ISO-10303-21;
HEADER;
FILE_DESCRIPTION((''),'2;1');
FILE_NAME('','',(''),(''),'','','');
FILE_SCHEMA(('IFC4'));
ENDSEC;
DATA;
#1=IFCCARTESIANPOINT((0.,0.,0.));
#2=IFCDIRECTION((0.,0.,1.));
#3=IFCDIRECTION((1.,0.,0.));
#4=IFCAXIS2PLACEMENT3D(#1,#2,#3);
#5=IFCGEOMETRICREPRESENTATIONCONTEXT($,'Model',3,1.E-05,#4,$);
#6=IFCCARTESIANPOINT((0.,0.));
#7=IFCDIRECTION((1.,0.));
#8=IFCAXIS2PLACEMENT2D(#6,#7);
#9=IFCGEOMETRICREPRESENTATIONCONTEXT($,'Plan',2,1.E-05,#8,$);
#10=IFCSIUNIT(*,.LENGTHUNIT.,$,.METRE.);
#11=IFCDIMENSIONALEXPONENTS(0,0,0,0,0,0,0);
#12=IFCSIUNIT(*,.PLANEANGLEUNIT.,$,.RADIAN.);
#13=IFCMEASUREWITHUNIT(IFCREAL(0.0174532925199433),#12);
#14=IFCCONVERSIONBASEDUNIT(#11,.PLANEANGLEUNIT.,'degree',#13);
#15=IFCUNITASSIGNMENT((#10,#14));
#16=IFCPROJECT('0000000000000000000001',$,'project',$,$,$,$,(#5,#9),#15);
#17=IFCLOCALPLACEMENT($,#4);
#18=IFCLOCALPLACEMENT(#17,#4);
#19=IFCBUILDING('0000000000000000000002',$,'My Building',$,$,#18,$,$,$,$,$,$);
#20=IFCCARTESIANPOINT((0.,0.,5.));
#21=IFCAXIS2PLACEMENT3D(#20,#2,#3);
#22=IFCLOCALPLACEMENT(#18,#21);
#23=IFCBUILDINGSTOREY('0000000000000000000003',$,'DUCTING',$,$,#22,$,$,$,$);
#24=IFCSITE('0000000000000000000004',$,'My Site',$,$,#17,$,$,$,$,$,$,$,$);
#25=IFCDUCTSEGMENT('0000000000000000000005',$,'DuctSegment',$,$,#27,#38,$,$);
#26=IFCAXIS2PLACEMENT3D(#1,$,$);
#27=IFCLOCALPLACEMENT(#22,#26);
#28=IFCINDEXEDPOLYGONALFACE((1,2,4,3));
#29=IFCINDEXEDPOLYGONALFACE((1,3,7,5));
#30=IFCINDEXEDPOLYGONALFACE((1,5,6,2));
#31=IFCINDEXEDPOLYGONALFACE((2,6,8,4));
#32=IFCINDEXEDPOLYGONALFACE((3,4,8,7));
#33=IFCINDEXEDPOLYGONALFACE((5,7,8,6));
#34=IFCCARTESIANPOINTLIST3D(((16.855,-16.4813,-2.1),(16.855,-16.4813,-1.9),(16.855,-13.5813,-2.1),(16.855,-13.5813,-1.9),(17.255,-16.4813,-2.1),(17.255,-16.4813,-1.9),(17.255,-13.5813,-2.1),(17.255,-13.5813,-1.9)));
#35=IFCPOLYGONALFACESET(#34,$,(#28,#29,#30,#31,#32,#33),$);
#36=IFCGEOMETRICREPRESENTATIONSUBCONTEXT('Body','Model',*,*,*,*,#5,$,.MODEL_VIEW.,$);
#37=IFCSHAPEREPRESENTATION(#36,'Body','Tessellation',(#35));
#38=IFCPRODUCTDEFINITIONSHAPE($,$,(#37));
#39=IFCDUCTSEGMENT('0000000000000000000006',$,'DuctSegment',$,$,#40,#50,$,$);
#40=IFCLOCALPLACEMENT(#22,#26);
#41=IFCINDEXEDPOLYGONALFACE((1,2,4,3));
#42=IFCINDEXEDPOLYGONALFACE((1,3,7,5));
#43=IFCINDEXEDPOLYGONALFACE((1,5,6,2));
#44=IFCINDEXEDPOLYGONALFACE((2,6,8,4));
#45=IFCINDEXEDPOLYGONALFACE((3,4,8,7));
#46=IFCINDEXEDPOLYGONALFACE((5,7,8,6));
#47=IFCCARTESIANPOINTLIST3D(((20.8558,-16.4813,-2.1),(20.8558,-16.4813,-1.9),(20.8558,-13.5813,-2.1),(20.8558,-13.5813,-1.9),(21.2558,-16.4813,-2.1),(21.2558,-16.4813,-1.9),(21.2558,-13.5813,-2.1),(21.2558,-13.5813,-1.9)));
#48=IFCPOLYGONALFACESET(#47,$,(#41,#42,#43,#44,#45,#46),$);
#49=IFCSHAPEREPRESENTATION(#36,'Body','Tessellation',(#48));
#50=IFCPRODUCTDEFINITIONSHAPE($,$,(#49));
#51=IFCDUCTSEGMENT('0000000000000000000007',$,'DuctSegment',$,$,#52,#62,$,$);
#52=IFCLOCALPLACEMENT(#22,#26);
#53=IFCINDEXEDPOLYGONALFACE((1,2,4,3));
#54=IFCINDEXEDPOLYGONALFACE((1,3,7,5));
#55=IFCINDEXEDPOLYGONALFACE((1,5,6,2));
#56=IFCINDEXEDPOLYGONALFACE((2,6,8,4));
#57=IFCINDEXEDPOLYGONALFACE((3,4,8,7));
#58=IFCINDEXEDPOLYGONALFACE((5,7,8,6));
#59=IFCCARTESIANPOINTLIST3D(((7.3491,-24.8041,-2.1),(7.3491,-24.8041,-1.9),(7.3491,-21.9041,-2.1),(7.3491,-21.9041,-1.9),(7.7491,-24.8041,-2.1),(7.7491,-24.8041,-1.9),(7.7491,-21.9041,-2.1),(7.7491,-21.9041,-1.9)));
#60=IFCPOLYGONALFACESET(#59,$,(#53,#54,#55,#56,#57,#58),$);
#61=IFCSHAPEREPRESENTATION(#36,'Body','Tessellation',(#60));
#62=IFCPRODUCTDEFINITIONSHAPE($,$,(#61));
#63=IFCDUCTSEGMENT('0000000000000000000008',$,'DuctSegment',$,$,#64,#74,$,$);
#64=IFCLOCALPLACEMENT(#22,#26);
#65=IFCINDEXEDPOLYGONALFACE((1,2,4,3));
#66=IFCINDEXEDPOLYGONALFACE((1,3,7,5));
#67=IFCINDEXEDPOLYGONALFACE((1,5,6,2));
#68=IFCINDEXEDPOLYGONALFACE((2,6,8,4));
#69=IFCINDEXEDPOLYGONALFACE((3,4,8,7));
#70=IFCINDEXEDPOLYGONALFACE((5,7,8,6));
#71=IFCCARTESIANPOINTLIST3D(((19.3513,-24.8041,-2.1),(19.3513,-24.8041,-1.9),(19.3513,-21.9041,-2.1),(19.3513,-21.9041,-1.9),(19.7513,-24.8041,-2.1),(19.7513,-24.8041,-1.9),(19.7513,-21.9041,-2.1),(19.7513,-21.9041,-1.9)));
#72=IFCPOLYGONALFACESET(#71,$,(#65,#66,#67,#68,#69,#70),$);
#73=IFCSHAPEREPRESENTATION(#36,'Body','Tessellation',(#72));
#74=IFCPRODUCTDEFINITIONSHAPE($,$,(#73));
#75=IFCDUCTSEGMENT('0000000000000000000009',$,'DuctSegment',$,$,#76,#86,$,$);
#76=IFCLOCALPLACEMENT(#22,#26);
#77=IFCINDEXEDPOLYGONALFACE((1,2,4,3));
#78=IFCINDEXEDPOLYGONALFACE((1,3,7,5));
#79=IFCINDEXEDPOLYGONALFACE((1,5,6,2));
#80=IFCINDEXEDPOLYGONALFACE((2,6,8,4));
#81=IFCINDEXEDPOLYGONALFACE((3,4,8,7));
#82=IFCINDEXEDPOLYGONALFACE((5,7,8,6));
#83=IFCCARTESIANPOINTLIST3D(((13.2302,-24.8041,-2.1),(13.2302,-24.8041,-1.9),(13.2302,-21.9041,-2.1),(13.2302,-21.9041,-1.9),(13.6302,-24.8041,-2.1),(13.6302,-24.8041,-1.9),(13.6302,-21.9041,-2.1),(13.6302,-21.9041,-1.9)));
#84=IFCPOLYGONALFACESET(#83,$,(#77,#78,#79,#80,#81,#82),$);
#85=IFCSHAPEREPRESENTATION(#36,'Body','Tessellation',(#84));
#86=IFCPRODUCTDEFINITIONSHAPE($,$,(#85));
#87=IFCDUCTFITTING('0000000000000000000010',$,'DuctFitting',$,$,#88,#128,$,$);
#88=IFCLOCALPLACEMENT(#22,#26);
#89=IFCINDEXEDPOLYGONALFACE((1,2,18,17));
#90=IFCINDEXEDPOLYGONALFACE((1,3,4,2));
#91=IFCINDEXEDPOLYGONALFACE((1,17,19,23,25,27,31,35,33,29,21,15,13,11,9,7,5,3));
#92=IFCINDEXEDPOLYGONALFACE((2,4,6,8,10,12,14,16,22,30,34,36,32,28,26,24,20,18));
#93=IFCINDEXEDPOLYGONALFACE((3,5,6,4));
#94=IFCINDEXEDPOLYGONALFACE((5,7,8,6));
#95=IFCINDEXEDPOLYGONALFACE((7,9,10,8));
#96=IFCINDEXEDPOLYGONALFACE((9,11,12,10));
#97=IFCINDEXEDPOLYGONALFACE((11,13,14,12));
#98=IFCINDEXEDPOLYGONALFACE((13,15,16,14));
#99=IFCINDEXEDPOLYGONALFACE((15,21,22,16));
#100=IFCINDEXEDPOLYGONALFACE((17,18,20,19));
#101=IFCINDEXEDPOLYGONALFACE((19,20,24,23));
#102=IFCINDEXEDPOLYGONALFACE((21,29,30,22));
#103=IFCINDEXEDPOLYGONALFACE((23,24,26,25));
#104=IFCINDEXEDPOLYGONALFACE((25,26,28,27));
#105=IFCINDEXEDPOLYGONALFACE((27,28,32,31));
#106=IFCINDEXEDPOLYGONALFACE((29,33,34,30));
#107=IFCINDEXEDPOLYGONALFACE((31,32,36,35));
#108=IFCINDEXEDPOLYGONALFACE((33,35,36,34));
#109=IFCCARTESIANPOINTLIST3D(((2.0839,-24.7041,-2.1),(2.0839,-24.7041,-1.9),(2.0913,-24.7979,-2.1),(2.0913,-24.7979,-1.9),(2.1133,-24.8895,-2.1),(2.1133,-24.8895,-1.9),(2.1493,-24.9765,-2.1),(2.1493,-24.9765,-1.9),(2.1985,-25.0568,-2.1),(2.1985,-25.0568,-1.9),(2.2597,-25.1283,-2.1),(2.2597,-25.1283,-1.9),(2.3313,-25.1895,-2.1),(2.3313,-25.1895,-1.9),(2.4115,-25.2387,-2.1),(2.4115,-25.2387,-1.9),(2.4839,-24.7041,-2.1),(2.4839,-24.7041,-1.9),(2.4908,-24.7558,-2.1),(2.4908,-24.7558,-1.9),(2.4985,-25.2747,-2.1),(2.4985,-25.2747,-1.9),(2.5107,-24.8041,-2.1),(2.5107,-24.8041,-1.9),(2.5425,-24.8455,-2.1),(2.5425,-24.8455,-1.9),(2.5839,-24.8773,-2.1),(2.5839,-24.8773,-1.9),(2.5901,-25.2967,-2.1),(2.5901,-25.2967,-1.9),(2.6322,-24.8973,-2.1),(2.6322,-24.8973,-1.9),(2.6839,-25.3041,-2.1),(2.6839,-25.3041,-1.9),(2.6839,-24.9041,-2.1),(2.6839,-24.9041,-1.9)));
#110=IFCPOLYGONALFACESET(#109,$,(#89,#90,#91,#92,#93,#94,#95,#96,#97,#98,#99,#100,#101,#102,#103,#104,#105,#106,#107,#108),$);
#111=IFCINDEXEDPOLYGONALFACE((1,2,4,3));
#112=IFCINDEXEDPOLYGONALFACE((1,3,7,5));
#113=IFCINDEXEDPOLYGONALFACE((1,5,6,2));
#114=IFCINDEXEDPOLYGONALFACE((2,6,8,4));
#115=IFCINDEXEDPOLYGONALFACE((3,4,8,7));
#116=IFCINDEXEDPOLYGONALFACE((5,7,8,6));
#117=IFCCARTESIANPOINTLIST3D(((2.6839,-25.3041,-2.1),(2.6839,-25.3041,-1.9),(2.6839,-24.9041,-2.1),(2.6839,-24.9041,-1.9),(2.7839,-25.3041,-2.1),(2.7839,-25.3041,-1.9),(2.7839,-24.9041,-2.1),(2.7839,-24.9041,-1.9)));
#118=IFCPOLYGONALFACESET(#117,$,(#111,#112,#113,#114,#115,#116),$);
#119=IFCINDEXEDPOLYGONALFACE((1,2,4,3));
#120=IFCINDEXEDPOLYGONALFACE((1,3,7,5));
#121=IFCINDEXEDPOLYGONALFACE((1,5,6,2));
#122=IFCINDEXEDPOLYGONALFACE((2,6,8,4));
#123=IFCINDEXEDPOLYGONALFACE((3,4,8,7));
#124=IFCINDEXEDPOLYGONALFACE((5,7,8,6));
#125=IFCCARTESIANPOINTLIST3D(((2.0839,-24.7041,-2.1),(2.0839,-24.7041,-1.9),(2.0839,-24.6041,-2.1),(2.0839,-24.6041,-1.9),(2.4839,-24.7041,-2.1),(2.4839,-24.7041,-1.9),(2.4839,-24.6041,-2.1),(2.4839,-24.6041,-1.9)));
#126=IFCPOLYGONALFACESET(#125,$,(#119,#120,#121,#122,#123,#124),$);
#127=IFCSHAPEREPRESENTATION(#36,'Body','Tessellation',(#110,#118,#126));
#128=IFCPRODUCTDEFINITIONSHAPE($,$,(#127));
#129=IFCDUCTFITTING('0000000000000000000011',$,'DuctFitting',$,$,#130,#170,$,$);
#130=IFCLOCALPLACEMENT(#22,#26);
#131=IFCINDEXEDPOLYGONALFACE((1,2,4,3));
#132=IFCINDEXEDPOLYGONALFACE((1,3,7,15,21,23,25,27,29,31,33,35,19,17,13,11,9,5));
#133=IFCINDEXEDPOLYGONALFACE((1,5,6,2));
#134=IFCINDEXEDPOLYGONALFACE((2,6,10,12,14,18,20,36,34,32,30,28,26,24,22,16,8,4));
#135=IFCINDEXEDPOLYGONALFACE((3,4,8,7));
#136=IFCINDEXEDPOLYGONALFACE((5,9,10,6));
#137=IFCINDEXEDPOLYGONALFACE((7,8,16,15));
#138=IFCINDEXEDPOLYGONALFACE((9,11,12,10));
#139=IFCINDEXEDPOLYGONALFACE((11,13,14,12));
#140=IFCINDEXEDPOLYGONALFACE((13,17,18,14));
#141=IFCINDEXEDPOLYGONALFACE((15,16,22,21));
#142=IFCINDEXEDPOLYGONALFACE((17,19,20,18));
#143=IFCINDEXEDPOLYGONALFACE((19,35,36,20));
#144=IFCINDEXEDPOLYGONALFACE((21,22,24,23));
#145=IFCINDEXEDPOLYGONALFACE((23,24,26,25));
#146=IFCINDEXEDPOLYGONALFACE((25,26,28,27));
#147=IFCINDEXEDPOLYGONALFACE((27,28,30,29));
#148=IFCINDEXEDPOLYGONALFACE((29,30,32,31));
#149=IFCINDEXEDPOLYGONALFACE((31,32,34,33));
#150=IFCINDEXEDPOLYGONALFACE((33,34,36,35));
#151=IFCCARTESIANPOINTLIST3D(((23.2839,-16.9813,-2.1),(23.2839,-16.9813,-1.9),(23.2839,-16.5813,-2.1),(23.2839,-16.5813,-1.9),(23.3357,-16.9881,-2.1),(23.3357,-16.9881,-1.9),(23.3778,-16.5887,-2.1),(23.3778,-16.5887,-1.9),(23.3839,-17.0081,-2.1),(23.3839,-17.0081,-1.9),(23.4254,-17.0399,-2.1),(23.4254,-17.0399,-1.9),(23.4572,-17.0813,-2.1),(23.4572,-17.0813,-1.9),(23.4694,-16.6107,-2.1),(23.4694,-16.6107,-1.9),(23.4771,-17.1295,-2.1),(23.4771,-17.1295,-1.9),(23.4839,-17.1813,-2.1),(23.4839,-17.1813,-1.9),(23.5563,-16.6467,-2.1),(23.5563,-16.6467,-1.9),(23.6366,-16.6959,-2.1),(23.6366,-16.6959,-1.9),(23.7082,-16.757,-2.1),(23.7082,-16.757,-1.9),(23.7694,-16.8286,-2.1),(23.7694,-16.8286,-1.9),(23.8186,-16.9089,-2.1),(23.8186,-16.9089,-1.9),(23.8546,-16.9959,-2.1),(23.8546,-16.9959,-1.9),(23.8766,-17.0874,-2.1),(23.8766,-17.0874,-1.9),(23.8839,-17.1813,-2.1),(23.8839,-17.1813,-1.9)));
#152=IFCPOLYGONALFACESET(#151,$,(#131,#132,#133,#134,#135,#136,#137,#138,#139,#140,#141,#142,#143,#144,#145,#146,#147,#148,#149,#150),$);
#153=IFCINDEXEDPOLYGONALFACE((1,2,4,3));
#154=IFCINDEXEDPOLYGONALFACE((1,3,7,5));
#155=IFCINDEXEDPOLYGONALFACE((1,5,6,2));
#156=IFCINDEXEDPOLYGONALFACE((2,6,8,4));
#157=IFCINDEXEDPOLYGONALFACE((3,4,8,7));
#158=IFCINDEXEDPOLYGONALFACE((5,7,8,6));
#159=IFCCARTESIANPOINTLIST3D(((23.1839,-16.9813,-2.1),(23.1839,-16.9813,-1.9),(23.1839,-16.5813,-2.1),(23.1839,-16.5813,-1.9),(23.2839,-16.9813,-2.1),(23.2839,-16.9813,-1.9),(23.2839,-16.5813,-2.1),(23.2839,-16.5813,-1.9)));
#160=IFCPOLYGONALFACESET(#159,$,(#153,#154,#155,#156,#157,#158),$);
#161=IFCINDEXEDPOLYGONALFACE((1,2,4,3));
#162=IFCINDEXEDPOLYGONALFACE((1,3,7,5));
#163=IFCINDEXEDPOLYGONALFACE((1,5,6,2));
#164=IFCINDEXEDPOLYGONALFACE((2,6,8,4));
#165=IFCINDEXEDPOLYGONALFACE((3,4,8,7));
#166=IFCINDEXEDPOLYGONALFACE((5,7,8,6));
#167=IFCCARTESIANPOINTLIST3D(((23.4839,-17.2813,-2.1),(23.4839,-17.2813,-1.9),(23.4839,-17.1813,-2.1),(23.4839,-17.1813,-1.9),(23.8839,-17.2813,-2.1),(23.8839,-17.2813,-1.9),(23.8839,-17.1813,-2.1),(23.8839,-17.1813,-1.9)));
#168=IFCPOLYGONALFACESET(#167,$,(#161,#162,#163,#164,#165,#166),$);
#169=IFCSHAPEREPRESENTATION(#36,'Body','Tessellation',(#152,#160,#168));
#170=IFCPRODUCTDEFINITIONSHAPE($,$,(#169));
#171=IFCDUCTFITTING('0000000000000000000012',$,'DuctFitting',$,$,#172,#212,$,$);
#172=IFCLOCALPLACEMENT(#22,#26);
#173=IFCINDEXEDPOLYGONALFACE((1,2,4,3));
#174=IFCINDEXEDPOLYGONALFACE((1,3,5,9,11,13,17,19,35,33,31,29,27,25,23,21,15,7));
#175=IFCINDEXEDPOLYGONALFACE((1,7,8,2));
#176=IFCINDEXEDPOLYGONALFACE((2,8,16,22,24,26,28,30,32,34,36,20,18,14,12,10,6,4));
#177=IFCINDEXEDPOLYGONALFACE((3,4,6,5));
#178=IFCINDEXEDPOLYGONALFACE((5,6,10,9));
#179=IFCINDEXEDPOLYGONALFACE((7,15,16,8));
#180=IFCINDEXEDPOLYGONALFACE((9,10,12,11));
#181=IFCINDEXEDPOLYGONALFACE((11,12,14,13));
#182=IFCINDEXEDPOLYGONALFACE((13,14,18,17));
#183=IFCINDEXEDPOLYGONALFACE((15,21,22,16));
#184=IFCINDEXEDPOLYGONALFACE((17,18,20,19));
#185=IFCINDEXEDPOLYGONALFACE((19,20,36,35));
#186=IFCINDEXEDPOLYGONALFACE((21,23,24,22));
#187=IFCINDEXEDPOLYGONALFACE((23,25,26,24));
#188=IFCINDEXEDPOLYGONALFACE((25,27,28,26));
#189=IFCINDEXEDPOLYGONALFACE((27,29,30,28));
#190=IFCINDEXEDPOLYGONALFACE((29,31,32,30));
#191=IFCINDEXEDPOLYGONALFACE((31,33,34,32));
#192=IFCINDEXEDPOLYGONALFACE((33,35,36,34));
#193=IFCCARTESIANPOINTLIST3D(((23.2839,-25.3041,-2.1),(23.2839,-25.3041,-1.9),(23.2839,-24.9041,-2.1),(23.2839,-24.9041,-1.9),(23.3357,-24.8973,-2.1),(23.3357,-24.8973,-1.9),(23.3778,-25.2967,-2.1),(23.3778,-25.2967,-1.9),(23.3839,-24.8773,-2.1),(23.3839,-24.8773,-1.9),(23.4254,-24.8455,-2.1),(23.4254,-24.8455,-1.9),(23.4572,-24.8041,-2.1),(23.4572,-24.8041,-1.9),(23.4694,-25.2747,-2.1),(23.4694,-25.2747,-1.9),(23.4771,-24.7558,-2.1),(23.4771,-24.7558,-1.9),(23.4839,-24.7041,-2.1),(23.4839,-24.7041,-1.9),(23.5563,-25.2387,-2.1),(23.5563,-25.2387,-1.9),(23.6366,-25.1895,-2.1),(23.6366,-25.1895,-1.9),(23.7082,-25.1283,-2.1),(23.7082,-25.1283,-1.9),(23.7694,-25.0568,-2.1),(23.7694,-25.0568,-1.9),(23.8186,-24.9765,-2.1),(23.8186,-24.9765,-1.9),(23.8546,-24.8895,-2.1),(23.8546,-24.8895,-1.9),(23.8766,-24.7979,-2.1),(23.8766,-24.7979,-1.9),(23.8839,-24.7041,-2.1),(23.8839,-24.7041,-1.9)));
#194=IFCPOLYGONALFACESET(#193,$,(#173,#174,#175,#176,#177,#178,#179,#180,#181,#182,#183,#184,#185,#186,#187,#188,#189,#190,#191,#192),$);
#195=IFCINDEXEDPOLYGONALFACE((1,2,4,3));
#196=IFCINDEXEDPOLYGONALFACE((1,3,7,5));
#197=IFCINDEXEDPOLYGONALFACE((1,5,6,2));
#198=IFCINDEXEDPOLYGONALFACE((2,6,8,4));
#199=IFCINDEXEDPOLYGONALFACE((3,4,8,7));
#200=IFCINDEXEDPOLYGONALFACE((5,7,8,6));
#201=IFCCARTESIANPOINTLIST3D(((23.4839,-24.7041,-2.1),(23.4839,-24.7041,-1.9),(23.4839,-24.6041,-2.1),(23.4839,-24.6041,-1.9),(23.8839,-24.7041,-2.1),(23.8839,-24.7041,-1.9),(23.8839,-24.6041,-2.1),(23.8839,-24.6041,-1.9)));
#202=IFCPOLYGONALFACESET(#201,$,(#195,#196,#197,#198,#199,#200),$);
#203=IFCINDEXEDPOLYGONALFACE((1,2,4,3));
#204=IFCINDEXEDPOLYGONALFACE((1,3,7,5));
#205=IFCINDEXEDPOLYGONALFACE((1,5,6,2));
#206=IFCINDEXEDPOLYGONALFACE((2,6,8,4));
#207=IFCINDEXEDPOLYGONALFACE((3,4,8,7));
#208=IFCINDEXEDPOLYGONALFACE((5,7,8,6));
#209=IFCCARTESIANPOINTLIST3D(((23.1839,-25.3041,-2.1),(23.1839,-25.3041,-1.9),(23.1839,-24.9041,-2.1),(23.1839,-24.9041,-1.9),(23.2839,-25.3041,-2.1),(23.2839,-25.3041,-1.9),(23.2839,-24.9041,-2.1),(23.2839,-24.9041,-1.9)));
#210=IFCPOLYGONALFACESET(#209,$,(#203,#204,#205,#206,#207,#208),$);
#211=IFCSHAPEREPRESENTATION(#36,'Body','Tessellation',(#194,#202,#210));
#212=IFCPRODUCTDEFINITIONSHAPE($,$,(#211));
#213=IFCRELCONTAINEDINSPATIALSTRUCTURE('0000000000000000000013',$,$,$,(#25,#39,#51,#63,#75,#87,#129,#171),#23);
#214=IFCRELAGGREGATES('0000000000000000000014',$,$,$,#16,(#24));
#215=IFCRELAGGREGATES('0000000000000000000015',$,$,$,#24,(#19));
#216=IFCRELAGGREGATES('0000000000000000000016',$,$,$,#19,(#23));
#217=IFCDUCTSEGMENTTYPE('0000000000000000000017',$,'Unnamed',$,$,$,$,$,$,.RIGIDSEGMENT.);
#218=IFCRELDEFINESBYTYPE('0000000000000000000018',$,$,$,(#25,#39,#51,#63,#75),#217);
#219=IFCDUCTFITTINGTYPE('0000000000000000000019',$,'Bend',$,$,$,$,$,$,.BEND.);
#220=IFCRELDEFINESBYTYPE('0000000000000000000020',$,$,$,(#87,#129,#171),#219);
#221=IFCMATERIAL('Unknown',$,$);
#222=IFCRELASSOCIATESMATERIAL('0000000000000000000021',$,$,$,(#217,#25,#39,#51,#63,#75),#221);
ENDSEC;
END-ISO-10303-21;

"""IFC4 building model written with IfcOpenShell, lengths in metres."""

from ifc_helpers import new_model, entity, si_unit, converted_unit, frame, origin_with_axes, origin_2d_with_axis, place, context, subcontext, project, spatial, line, arc, indexed_curve, rectangle, outline, extrude, source, transform, mapped, material, material_profile, profile_set, profile_usage, type_object, type_shapes, element, save


model = new_model("IFC4")

# Units and contexts
model_context = context("Model", 3, precision=1e-05, world=origin_with_axes())
plan_context = context("Plan", 2, precision=1e-05, world=origin_2d_with_axis())
body_context = subcontext(model_context, "Body", "Model", "MODEL_VIEW")
ifc_project = project(units=[si_unit("LENGTHUNIT", "METRE"), converted_unit("PLANEANGLEUNIT", "degree", entity("IfcReal", 0.0174532925199433), si_unit("PLANEANGLEUNIT", "RADIAN"), dimensions=[0, 0, 0, 0, 0, 0, 0])], contexts=[model_context, plan_context])

# Site, building, storey
site_placement = place(None, origin_with_axes())
site = spatial("IfcSite", under=ifc_project, at=site_placement, Name="My Site")
building_placement = place(site_placement, origin_with_axes())
building = spatial("IfcBuilding", under=site, at=building_placement, Name="My Building")
storey_placement = place(building_placement, frame((0.0, 0.0, 5.0), z_axis=(0.0, 0.0, 1.0), x_axis=(1.0, 0.0, 0.0)))
storey = spatial("IfcBuildingStorey", under=building, at=storey_placement, Name="DUCTING")

# Duct segments
ifc_material = material(Name="Unknown")
ifc_material_profile = material_profile(ifc_material, rectangle(XDim=0.4, YDim=0.2))
ifc_profile_set = profile_set([ifc_material_profile])
duct_segment_type = type_object("IfcDuctSegmentType", Name="Unnamed", PredefinedType="RIGIDSEGMENT", material=ifc_profile_set)
ifc_profile_usage_1 = profile_usage(ifc_profile_set, cardinal=5)
duct_segment_1_placement = place(storey_placement, frame((17.055, -13.5813, -2.0), z_axis=(0.0, -1.0, 0.0), x_axis=(1.0, 0.0, 0.0)))
element("IfcDuctSegment", 1, at=duct_segment_1_placement, inside=storey, type_object=duct_segment_type, material=ifc_profile_usage_1, Name="DuctSegment", context=body_context, shape_type="SweptSolid", body=[
    extrude(rectangle(XDim=0.4, YDim=0.2), origin_with_axes(), (0.0, 0.0, 1.0), 2.9),
])
ifc_profile_usage_2 = profile_usage(ifc_profile_set, cardinal=5)
duct_segment_2_placement = place(storey_placement, frame((21.0558, -13.5813, -2.0), z_axis=(0.0, -1.0, 0.0), x_axis=(1.0, 0.0, 0.0)))
element("IfcDuctSegment", 2, at=duct_segment_2_placement, inside=storey, type_object=duct_segment_type, material=ifc_profile_usage_2, Name="DuctSegment", context=body_context, shape_type="SweptSolid", body=[
    extrude(rectangle(XDim=0.4, YDim=0.2), origin_with_axes(), (0.0, 0.0, 1.0), 2.9),
])
ifc_profile_usage_3 = profile_usage(ifc_profile_set, cardinal=5)
duct_segment_3_placement = place(storey_placement, frame((7.5491, -21.9041, -2.0), z_axis=(0.0, -1.0, 0.0), x_axis=(1.0, 0.0, 0.0)))
element("IfcDuctSegment", 3, at=duct_segment_3_placement, inside=storey, type_object=duct_segment_type, material=ifc_profile_usage_3, Name="DuctSegment", context=body_context, shape_type="SweptSolid", body=[
    extrude(rectangle(XDim=0.4, YDim=0.2), origin_with_axes(), (0.0, 0.0, 1.0), 2.9),
])
ifc_profile_usage_4 = profile_usage(ifc_profile_set, cardinal=5)
duct_segment_4_placement = place(storey_placement, frame((19.5513, -21.9041, -2.0), z_axis=(0.0, -1.0, 0.0), x_axis=(1.0, 0.0, 0.0)))
element("IfcDuctSegment", 4, at=duct_segment_4_placement, inside=storey, type_object=duct_segment_type, material=ifc_profile_usage_4, Name="DuctSegment", context=body_context, shape_type="SweptSolid", body=[
    extrude(rectangle(XDim=0.4, YDim=0.2), origin_with_axes(), (0.0, 0.0, 1.0), 2.9),
])
ifc_profile_usage_5 = profile_usage(ifc_profile_set, cardinal=5)
duct_segment_5_placement = place(storey_placement, frame((13.4302, -21.9041, -2.0), z_axis=(0.0, -1.0, 0.0), x_axis=(1.0, 0.0, 0.0)))
element("IfcDuctSegment", 5, at=duct_segment_5_placement, inside=storey, type_object=duct_segment_type, material=ifc_profile_usage_5, Name="DuctSegment", context=body_context, shape_type="SweptSolid", body=[
    extrude(rectangle(XDim=0.4, YDim=0.2), origin_with_axes(), (0.0, 0.0, 1.0), 2.9),
])

# Duct fittings
duct_fitting_type = type_object("IfcDuctFittingType", Name="Bend", PredefinedType="BEND")
shared_shape = source(origin_with_axes(), body_context, "Body", "SweptSolid", [
    extrude(outline(indexed_curve([(0.2, 0.0), (0.2586, -0.1414), (0.4, -0.2), (0.4, -0.6), (-0.0243, -0.4243), (-0.2, 0.0)], segments=[arc(1, 2, 3), line(3, 4), arc(4, 5, 6), line(6, 1)])), frame((0.0, -0.1, -0.1), z_axis=(0.0, -1.0, 0.0), x_axis=(1.0, 0.0, 0.0)), (0.0, 0.0, -1.0), 0.2),
    extrude(rectangle(XDim=0.4, YDim=0.2), origin_with_axes(), (0.0, 0.0, -1.0), 0.1),
    extrude(rectangle(XDim=0.4, YDim=0.2), frame((0.4, 0.0, -0.5), z_axis=(1.0, 0.0, 0.0), x_axis=(0.0, 0.0, 1.0)), (0.0, 0.0, 1.0), 0.1),
])
type_shapes(duct_fitting_type, [shared_shape])
for number, where, z_axis, x_axis, name in (
    (6, (2.7839, -25.1041, -2.0), (1.0, 0.0, 0.0), (0.0, 1.0, 0.0), "DuctFitting"),
    (7, (23.1839, -16.7813, -2.0), (-1.0, 0.0, 0.0), (0.0, -1.0, 0.0), "DuctFitting"),
    (8, (23.6839, -24.6041, -2.0), (0.000001, 1.0, 0.0), (-1.0, 0.000001, 0.0), "DuctFitting"),
):
    element("IfcDuctFitting", number, at=place(storey_placement, frame(where, z_axis=z_axis, x_axis=x_axis)), inside=storey, type_object=duct_fitting_type, Name=name, context=body_context, shape_type="MappedRepresentation", body=[
        mapped(shared_shape, transform((0.0, 0.0, 0.0), x_axis=(1.0, 0.0, 0.0), y_axis=(0.0, 1.0, 0.0), z_axis=(0.0, 0.0, 1.0), scale=1.0)),
    ])

save(model, "model.ifc")
